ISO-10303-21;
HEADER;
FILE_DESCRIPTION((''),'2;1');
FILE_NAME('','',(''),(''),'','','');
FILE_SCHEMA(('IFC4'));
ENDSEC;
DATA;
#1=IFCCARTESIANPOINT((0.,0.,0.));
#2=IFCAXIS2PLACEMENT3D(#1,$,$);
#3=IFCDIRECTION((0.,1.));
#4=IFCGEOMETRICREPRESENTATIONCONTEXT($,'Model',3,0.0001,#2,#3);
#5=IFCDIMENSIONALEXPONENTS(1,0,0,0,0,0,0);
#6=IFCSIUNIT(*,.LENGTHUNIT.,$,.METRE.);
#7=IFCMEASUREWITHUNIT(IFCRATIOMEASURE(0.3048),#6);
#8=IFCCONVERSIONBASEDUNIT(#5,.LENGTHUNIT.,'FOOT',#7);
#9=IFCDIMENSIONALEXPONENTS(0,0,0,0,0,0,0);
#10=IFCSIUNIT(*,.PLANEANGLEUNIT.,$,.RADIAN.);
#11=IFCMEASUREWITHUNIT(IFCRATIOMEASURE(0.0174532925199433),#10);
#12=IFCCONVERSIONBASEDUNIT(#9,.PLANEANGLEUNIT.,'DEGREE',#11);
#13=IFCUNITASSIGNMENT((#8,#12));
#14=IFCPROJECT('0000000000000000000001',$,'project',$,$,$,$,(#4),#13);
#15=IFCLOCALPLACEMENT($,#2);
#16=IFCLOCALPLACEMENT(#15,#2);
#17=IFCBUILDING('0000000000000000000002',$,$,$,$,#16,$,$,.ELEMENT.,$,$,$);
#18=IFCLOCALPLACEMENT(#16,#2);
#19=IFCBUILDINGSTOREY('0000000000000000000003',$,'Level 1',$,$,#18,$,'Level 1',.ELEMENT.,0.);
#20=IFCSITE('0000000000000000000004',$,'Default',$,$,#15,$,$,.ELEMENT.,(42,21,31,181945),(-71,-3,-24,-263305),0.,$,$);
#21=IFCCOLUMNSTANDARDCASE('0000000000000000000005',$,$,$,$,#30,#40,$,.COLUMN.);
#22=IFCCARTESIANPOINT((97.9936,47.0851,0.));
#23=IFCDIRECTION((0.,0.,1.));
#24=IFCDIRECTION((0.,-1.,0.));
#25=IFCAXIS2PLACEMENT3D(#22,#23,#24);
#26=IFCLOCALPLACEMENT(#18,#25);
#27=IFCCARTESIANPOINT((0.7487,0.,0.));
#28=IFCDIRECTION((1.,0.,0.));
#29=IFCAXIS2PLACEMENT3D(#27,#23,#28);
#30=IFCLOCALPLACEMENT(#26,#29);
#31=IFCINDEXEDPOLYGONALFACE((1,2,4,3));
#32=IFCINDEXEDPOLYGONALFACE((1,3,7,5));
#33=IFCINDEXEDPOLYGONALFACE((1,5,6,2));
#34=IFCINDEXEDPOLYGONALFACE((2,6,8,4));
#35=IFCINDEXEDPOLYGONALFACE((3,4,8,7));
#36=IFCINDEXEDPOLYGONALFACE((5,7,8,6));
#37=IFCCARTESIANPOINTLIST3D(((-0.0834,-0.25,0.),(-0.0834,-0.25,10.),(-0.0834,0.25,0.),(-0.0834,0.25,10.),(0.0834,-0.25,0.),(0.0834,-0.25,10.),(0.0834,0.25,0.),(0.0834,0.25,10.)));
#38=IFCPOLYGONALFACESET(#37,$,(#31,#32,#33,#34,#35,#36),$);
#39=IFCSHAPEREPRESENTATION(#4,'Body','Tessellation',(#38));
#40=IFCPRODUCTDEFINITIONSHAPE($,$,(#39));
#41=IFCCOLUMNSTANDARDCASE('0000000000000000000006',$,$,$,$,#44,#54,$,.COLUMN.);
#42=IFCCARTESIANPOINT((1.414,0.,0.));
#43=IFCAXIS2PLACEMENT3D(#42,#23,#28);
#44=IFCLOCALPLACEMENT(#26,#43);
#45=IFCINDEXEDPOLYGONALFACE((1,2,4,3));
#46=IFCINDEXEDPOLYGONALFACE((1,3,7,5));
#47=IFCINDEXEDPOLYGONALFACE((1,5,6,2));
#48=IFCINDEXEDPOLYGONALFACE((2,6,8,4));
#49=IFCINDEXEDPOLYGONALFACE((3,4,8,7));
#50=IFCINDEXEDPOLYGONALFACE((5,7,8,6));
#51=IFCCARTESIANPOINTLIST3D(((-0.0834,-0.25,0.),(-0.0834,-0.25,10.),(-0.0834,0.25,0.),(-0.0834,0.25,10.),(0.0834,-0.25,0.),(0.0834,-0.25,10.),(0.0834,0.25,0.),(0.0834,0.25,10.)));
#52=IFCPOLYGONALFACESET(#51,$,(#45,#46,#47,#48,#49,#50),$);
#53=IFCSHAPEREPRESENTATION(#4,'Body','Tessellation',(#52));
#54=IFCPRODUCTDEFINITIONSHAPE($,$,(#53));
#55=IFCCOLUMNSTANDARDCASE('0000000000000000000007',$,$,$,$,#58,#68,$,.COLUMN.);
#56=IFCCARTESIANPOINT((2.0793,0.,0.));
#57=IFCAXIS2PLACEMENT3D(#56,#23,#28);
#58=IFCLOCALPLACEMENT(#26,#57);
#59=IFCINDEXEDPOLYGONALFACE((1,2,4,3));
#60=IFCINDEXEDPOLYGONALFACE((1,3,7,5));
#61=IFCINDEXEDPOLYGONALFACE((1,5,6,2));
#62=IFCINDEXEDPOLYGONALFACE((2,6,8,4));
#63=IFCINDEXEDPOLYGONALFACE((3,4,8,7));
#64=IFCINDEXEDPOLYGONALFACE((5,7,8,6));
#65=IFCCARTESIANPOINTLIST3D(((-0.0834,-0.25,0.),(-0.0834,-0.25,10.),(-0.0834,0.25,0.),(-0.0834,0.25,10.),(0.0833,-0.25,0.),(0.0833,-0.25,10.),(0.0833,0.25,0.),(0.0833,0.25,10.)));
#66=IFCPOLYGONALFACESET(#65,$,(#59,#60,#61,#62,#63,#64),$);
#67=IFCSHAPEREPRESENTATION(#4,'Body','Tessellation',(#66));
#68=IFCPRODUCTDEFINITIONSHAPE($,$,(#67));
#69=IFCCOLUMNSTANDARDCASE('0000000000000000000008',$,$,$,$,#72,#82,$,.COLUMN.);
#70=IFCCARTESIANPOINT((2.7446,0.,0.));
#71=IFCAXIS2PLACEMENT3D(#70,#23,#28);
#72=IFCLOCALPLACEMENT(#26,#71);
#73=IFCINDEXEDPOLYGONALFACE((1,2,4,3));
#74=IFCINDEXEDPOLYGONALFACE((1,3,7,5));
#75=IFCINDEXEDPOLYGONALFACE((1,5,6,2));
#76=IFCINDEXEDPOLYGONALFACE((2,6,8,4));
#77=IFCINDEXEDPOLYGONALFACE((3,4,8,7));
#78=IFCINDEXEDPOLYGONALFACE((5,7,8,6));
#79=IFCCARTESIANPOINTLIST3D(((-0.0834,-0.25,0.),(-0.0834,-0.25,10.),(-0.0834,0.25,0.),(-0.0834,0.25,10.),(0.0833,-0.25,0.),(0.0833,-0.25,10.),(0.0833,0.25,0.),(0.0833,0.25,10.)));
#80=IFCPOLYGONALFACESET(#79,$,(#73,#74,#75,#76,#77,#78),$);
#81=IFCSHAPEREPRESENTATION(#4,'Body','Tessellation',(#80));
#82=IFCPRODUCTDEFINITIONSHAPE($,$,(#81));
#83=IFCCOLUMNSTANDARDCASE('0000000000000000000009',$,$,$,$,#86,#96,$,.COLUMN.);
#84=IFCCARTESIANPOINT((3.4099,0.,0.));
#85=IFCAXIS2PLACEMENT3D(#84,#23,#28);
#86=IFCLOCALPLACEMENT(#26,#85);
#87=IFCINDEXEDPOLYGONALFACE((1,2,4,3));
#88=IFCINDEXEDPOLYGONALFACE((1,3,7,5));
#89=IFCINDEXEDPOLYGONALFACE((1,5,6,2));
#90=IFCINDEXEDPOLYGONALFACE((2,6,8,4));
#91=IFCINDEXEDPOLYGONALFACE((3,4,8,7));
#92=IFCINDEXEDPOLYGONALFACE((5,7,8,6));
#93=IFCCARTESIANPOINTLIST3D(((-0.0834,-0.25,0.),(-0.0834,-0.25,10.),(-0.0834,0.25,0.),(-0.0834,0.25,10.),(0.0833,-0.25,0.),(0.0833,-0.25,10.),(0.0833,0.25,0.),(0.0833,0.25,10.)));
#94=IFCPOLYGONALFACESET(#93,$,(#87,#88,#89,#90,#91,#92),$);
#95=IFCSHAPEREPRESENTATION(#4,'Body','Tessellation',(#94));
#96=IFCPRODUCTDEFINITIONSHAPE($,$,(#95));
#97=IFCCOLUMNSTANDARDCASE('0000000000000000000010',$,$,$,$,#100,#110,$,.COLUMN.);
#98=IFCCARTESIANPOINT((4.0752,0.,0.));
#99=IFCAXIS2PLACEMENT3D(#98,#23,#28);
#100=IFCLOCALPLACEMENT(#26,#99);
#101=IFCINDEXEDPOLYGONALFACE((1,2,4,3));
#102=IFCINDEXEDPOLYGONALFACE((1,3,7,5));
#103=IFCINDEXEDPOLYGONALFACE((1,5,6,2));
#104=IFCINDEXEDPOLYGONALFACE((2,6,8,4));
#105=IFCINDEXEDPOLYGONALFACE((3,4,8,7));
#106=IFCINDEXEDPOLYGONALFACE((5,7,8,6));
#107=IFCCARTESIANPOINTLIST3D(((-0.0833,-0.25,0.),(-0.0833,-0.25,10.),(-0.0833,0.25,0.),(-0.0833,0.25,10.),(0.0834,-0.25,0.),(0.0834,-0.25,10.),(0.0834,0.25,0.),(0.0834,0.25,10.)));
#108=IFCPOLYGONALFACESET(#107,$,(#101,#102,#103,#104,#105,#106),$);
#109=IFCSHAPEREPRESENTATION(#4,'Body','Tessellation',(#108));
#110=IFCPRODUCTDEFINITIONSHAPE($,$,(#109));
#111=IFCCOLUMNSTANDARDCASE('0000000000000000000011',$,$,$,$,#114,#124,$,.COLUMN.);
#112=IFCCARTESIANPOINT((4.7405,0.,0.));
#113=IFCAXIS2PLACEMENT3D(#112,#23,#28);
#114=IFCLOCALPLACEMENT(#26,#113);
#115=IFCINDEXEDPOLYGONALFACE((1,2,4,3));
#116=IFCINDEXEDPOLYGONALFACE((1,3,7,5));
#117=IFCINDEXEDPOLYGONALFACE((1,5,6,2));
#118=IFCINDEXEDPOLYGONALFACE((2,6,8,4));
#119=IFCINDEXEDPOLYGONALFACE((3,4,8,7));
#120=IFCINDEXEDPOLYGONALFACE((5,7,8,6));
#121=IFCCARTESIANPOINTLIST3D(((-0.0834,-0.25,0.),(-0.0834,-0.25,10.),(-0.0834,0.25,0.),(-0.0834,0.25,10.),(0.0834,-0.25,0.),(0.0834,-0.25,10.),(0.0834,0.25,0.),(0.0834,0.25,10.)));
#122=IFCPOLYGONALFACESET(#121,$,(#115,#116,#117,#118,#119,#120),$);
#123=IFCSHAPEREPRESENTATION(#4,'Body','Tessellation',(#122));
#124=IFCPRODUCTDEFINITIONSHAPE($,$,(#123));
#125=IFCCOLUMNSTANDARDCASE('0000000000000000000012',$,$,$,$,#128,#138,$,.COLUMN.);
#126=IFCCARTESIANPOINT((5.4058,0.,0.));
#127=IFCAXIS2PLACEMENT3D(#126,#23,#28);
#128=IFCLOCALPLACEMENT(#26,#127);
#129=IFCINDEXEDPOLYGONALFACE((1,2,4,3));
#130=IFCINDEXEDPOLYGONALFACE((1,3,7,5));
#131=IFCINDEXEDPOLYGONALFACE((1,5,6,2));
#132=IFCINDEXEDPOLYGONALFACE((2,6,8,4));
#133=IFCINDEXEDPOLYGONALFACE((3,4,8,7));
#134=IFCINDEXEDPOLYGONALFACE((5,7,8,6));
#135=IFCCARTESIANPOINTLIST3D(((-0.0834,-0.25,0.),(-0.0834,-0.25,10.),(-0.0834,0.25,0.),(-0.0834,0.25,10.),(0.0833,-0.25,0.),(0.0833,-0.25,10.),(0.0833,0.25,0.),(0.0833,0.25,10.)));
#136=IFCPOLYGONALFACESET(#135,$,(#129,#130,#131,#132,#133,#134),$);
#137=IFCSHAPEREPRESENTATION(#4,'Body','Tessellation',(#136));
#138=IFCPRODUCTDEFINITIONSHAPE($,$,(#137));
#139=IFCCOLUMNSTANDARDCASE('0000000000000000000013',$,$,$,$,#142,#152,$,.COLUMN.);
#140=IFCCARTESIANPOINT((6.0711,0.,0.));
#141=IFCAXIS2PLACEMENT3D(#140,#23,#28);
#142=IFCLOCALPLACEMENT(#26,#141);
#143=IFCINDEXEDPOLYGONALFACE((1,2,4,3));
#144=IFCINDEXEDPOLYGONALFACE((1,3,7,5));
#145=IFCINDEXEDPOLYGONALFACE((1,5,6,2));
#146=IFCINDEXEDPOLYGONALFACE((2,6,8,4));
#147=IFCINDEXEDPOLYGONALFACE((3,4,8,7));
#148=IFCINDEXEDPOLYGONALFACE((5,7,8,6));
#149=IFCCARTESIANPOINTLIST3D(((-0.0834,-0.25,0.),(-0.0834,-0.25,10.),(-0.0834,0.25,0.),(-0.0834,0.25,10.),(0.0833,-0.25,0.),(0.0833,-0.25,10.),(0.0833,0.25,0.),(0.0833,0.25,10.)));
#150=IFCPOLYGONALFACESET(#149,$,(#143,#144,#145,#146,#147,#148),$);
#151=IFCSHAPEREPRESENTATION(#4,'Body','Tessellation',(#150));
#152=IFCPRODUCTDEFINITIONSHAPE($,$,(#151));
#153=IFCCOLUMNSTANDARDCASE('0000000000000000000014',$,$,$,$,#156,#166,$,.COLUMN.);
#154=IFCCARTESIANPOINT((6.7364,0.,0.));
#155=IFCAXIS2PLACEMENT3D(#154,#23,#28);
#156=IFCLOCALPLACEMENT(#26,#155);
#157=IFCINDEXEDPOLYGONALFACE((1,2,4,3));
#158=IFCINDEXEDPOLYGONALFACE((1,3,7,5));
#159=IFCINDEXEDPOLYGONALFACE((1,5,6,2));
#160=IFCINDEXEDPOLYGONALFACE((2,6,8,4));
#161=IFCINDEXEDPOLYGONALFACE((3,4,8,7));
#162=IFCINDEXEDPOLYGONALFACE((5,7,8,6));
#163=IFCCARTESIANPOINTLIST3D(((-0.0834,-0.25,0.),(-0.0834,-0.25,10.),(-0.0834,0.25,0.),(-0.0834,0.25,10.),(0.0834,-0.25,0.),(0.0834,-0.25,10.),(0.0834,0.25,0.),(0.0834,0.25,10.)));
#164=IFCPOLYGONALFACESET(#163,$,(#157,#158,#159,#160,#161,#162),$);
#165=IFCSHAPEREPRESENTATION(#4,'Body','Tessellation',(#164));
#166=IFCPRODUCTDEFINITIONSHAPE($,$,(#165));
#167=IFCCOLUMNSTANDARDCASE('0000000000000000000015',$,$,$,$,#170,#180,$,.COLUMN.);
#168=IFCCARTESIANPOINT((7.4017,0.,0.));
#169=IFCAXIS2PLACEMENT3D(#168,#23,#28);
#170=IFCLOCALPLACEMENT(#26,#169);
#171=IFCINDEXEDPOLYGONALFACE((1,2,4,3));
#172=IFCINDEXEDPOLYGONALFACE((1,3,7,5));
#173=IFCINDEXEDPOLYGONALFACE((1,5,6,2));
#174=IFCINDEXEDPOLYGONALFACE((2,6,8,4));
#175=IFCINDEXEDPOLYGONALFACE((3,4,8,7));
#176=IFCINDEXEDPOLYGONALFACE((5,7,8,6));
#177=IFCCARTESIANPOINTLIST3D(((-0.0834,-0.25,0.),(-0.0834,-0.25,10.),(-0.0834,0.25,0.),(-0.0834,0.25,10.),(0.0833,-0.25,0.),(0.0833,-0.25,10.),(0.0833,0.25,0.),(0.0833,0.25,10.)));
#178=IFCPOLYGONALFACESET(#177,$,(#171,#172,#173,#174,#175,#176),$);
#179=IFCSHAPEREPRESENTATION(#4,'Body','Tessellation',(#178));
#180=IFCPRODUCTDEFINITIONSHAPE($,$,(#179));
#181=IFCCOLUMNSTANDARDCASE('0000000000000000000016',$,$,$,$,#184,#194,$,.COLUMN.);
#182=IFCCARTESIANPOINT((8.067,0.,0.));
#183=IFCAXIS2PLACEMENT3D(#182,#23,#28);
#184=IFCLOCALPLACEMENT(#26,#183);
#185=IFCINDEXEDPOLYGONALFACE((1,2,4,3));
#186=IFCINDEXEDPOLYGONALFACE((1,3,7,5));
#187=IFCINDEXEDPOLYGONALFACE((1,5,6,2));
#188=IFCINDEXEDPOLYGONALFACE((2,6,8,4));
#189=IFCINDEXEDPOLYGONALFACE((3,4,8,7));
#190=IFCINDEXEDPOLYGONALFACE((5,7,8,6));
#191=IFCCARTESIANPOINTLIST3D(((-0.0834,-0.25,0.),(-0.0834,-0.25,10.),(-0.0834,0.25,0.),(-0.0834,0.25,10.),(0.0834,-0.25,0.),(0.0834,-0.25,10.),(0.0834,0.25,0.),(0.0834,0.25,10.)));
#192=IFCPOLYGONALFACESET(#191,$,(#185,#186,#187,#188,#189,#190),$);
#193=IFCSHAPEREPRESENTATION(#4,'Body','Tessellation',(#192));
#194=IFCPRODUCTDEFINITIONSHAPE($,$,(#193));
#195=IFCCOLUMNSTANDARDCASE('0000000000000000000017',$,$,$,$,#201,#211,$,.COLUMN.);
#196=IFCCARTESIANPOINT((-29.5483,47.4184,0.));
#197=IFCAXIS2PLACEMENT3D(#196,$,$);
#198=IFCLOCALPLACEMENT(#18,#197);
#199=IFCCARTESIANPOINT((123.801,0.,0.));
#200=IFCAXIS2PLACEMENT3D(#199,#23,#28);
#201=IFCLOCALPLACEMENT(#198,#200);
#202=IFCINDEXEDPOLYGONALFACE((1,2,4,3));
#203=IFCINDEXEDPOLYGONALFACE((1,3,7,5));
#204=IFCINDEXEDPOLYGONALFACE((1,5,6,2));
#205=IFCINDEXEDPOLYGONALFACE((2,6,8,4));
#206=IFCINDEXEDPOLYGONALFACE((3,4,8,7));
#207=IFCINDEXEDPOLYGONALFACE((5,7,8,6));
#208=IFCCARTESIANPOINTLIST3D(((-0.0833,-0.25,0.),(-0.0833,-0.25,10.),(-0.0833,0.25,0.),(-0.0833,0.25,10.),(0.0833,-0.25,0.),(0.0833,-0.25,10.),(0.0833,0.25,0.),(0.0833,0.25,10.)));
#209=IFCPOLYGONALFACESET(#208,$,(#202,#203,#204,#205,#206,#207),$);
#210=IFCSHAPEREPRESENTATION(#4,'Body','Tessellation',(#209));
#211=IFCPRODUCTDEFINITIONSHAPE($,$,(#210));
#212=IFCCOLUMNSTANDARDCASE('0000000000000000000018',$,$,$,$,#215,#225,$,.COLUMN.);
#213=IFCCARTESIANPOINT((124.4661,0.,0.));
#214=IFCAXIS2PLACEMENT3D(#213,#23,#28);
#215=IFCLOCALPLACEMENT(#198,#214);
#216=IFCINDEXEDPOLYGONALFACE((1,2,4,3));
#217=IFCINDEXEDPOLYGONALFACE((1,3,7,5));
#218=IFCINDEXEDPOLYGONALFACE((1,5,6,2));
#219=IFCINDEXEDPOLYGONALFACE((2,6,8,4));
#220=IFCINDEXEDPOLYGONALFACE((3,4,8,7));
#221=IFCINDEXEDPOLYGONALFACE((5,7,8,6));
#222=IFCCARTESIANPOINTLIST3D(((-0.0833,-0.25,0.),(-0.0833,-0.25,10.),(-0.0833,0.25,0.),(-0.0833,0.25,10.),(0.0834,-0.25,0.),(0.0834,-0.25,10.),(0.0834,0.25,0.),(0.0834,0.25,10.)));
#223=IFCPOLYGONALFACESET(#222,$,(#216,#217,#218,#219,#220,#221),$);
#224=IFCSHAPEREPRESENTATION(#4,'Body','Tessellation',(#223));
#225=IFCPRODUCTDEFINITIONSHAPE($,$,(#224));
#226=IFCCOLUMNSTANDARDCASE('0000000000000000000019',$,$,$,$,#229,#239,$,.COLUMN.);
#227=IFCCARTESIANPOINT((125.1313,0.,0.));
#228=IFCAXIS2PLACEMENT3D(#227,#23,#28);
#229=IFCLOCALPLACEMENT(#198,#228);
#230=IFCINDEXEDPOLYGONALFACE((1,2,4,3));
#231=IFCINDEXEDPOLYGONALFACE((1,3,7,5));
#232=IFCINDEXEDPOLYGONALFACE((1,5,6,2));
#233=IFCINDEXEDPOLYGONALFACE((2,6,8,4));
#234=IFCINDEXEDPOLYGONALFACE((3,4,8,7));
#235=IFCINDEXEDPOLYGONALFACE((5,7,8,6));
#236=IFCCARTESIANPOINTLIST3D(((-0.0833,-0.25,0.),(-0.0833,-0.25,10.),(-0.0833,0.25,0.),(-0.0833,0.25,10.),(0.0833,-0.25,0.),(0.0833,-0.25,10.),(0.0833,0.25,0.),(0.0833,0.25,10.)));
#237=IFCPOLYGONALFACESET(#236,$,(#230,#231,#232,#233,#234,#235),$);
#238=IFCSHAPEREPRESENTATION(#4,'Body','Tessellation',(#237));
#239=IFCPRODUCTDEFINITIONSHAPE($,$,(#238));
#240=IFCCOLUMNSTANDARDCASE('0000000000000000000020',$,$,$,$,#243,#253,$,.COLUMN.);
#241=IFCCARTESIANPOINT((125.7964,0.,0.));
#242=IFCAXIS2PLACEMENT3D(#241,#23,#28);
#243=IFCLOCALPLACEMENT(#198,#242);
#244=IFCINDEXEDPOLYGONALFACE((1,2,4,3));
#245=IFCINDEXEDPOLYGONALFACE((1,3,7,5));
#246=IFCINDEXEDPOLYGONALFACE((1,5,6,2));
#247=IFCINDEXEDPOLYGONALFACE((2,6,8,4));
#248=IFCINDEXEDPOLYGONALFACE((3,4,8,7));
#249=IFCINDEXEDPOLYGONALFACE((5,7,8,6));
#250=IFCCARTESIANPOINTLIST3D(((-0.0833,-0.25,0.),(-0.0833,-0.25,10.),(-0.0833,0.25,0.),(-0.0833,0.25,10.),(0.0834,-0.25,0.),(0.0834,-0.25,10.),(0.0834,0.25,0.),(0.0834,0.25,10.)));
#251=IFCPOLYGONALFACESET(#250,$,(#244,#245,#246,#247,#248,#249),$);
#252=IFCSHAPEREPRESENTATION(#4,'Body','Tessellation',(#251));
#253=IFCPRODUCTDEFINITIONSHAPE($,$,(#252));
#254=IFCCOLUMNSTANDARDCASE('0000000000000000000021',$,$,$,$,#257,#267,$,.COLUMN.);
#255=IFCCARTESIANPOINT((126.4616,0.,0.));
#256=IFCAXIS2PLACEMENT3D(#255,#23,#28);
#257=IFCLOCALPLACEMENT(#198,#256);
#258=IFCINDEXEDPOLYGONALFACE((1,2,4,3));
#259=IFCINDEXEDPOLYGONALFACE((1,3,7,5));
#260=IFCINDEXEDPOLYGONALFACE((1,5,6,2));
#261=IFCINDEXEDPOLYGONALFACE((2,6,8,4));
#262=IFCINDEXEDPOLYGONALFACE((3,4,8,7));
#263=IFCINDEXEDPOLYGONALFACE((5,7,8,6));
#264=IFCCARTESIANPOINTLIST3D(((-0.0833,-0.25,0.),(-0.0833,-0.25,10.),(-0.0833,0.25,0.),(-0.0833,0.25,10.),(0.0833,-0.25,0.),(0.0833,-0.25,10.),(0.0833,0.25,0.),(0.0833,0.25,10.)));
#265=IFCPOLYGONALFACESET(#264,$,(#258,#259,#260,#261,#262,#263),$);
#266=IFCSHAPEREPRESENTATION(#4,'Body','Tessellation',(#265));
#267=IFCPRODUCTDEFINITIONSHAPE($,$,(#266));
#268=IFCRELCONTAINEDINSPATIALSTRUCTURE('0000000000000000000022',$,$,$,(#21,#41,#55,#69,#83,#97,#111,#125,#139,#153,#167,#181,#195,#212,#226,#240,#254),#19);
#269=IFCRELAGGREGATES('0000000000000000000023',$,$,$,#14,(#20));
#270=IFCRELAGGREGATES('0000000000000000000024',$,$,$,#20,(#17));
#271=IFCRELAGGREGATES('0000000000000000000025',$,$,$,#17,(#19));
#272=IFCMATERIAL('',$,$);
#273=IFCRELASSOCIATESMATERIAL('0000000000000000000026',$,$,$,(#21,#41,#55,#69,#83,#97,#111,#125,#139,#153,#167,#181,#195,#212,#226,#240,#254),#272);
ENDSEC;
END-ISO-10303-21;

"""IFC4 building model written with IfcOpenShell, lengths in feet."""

from ifc_helpers import new_model, entity, si_unit, converted_unit, direction, frame, origin, place, context, project, spatial, rectangle, extrude, material, element, save


model = new_model("IFC4")

# Units and contexts
model_context = context("Model", 3, precision=0.0001, world=origin(), true_north=direction((0.0, 1.0)))
ifc_project = project(units=[converted_unit("LENGTHUNIT", "FOOT", entity("IfcRatioMeasure", 0.3048), si_unit("LENGTHUNIT", "METRE"), dimensions=[1, 0, 0, 0, 0, 0, 0]), converted_unit("PLANEANGLEUNIT", "DEGREE", entity("IfcRatioMeasure", 0.0174532925199433), si_unit("PLANEANGLEUNIT", "RADIAN"), dimensions=[0, 0, 0, 0, 0, 0, 0])], contexts=[model_context])

# Site, building, storey
site_placement = place(None, origin())
site = spatial("IfcSite", under=ifc_project, at=site_placement, Name="Default", CompositionType="ELEMENT", RefLatitude=(42, 21, 31, 181945), RefLongitude=(-71, -3, -24, -263305), RefElevation=0.0)
building_placement = place(site_placement, origin())
building = spatial("IfcBuilding", under=site, at=building_placement, CompositionType="ELEMENT")
storey_placement = place(building_placement, origin())
storey = spatial("IfcBuildingStorey", under=building, at=storey_placement, Name="Level 1", LongName="Level 1", CompositionType="ELEMENT", Elevation=0.0)

# Columns
ifc_material_1 = material(Name="")
wall_placement = place(storey_placement, frame((97.9936, 47.0851, 0.0), z_axis=(0.0, 0.0, 1.0), x_axis=(0.0, -1.0, 0.0)))
for number, where, z_axis, x_axis in (
    (1, (0.7487, 0.0, 0.0), (0.0, 0.0, 1.0), (1.0, 0.0, 0.0)),
    (2, (1.414, 0.0, 0.0), (0.0, 0.0, 1.0), (1.0, 0.0, 0.0)),
    (3, (2.0793, 0.0, 0.0), (0.0, 0.0, 1.0), (1.0, 0.0, 0.0)),
    (4, (2.7446, 0.0, 0.0), (0.0, 0.0, 1.0), (1.0, 0.0, 0.0)),
    (5, (3.4099, 0.0, 0.0), (0.0, 0.0, 1.0), (1.0, 0.0, 0.0)),
    (6, (4.0752, 0.0, 0.0), (0.0, 0.0, 1.0), (1.0, 0.0, 0.0)),
    (7, (4.7405, 0.0, 0.0), (0.0, 0.0, 1.0), (1.0, 0.0, 0.0)),
    (8, (5.4058, 0.0, 0.0), (0.0, 0.0, 1.0), (1.0, 0.0, 0.0)),
    (9, (6.0711, 0.0, 0.0), (0.0, 0.0, 1.0), (1.0, 0.0, 0.0)),
    (10, (6.7364, 0.0, 0.0), (0.0, 0.0, 1.0), (1.0, 0.0, 0.0)),
    (11, (7.4017, 0.0, 0.0), (0.0, 0.0, 1.0), (1.0, 0.0, 0.0)),
    (12, (8.067, 0.0, 0.0), (0.0, 0.0, 1.0), (1.0, 0.0, 0.0)),
):
    element("IfcColumnStandardCase", number, at=place(wall_placement, frame(where, z_axis=z_axis, x_axis=x_axis)), inside=storey, material=ifc_material_1, PredefinedType="COLUMN", context=model_context, shape_type="SweptSolid", body=[
        extrude(rectangle(XDim=0.1667, YDim=0.5), origin(), (0.0, 0.0, 1.0), 10.0),
    ])
placement = place(storey_placement, frame((-29.5483, 47.4184, 0.0)))
for number, where, z_axis, x_axis in (
    (13, (123.801, 0.0, 0.0), (0.0, 0.0, 1.0), (1.0, 0.0, 0.0)),
    (14, (124.4661, 0.0, 0.0), (0.0, 0.0, 1.0), (1.0, 0.0, 0.0)),
    (15, (125.1313, 0.0, 0.0), (0.0, 0.0, 1.0), (1.0, 0.0, 0.0)),
    (16, (125.7964, 0.0, 0.0), (0.0, 0.0, 1.0), (1.0, 0.0, 0.0)),
    (17, (126.4616, 0.0, 0.0), (0.0, 0.0, 1.0), (1.0, 0.0, 0.0)),
):
    element("IfcColumnStandardCase", number, at=place(placement, frame(where, z_axis=z_axis, x_axis=x_axis)), inside=storey, material=ifc_material_1, PredefinedType="COLUMN", context=model_context, shape_type="SweptSolid", body=[
        extrude(rectangle(XDim=0.1667, YDim=0.5), origin(), (0.0, 0.0, 1.0), 10.0),
    ])

save(model, "model.ifc")
